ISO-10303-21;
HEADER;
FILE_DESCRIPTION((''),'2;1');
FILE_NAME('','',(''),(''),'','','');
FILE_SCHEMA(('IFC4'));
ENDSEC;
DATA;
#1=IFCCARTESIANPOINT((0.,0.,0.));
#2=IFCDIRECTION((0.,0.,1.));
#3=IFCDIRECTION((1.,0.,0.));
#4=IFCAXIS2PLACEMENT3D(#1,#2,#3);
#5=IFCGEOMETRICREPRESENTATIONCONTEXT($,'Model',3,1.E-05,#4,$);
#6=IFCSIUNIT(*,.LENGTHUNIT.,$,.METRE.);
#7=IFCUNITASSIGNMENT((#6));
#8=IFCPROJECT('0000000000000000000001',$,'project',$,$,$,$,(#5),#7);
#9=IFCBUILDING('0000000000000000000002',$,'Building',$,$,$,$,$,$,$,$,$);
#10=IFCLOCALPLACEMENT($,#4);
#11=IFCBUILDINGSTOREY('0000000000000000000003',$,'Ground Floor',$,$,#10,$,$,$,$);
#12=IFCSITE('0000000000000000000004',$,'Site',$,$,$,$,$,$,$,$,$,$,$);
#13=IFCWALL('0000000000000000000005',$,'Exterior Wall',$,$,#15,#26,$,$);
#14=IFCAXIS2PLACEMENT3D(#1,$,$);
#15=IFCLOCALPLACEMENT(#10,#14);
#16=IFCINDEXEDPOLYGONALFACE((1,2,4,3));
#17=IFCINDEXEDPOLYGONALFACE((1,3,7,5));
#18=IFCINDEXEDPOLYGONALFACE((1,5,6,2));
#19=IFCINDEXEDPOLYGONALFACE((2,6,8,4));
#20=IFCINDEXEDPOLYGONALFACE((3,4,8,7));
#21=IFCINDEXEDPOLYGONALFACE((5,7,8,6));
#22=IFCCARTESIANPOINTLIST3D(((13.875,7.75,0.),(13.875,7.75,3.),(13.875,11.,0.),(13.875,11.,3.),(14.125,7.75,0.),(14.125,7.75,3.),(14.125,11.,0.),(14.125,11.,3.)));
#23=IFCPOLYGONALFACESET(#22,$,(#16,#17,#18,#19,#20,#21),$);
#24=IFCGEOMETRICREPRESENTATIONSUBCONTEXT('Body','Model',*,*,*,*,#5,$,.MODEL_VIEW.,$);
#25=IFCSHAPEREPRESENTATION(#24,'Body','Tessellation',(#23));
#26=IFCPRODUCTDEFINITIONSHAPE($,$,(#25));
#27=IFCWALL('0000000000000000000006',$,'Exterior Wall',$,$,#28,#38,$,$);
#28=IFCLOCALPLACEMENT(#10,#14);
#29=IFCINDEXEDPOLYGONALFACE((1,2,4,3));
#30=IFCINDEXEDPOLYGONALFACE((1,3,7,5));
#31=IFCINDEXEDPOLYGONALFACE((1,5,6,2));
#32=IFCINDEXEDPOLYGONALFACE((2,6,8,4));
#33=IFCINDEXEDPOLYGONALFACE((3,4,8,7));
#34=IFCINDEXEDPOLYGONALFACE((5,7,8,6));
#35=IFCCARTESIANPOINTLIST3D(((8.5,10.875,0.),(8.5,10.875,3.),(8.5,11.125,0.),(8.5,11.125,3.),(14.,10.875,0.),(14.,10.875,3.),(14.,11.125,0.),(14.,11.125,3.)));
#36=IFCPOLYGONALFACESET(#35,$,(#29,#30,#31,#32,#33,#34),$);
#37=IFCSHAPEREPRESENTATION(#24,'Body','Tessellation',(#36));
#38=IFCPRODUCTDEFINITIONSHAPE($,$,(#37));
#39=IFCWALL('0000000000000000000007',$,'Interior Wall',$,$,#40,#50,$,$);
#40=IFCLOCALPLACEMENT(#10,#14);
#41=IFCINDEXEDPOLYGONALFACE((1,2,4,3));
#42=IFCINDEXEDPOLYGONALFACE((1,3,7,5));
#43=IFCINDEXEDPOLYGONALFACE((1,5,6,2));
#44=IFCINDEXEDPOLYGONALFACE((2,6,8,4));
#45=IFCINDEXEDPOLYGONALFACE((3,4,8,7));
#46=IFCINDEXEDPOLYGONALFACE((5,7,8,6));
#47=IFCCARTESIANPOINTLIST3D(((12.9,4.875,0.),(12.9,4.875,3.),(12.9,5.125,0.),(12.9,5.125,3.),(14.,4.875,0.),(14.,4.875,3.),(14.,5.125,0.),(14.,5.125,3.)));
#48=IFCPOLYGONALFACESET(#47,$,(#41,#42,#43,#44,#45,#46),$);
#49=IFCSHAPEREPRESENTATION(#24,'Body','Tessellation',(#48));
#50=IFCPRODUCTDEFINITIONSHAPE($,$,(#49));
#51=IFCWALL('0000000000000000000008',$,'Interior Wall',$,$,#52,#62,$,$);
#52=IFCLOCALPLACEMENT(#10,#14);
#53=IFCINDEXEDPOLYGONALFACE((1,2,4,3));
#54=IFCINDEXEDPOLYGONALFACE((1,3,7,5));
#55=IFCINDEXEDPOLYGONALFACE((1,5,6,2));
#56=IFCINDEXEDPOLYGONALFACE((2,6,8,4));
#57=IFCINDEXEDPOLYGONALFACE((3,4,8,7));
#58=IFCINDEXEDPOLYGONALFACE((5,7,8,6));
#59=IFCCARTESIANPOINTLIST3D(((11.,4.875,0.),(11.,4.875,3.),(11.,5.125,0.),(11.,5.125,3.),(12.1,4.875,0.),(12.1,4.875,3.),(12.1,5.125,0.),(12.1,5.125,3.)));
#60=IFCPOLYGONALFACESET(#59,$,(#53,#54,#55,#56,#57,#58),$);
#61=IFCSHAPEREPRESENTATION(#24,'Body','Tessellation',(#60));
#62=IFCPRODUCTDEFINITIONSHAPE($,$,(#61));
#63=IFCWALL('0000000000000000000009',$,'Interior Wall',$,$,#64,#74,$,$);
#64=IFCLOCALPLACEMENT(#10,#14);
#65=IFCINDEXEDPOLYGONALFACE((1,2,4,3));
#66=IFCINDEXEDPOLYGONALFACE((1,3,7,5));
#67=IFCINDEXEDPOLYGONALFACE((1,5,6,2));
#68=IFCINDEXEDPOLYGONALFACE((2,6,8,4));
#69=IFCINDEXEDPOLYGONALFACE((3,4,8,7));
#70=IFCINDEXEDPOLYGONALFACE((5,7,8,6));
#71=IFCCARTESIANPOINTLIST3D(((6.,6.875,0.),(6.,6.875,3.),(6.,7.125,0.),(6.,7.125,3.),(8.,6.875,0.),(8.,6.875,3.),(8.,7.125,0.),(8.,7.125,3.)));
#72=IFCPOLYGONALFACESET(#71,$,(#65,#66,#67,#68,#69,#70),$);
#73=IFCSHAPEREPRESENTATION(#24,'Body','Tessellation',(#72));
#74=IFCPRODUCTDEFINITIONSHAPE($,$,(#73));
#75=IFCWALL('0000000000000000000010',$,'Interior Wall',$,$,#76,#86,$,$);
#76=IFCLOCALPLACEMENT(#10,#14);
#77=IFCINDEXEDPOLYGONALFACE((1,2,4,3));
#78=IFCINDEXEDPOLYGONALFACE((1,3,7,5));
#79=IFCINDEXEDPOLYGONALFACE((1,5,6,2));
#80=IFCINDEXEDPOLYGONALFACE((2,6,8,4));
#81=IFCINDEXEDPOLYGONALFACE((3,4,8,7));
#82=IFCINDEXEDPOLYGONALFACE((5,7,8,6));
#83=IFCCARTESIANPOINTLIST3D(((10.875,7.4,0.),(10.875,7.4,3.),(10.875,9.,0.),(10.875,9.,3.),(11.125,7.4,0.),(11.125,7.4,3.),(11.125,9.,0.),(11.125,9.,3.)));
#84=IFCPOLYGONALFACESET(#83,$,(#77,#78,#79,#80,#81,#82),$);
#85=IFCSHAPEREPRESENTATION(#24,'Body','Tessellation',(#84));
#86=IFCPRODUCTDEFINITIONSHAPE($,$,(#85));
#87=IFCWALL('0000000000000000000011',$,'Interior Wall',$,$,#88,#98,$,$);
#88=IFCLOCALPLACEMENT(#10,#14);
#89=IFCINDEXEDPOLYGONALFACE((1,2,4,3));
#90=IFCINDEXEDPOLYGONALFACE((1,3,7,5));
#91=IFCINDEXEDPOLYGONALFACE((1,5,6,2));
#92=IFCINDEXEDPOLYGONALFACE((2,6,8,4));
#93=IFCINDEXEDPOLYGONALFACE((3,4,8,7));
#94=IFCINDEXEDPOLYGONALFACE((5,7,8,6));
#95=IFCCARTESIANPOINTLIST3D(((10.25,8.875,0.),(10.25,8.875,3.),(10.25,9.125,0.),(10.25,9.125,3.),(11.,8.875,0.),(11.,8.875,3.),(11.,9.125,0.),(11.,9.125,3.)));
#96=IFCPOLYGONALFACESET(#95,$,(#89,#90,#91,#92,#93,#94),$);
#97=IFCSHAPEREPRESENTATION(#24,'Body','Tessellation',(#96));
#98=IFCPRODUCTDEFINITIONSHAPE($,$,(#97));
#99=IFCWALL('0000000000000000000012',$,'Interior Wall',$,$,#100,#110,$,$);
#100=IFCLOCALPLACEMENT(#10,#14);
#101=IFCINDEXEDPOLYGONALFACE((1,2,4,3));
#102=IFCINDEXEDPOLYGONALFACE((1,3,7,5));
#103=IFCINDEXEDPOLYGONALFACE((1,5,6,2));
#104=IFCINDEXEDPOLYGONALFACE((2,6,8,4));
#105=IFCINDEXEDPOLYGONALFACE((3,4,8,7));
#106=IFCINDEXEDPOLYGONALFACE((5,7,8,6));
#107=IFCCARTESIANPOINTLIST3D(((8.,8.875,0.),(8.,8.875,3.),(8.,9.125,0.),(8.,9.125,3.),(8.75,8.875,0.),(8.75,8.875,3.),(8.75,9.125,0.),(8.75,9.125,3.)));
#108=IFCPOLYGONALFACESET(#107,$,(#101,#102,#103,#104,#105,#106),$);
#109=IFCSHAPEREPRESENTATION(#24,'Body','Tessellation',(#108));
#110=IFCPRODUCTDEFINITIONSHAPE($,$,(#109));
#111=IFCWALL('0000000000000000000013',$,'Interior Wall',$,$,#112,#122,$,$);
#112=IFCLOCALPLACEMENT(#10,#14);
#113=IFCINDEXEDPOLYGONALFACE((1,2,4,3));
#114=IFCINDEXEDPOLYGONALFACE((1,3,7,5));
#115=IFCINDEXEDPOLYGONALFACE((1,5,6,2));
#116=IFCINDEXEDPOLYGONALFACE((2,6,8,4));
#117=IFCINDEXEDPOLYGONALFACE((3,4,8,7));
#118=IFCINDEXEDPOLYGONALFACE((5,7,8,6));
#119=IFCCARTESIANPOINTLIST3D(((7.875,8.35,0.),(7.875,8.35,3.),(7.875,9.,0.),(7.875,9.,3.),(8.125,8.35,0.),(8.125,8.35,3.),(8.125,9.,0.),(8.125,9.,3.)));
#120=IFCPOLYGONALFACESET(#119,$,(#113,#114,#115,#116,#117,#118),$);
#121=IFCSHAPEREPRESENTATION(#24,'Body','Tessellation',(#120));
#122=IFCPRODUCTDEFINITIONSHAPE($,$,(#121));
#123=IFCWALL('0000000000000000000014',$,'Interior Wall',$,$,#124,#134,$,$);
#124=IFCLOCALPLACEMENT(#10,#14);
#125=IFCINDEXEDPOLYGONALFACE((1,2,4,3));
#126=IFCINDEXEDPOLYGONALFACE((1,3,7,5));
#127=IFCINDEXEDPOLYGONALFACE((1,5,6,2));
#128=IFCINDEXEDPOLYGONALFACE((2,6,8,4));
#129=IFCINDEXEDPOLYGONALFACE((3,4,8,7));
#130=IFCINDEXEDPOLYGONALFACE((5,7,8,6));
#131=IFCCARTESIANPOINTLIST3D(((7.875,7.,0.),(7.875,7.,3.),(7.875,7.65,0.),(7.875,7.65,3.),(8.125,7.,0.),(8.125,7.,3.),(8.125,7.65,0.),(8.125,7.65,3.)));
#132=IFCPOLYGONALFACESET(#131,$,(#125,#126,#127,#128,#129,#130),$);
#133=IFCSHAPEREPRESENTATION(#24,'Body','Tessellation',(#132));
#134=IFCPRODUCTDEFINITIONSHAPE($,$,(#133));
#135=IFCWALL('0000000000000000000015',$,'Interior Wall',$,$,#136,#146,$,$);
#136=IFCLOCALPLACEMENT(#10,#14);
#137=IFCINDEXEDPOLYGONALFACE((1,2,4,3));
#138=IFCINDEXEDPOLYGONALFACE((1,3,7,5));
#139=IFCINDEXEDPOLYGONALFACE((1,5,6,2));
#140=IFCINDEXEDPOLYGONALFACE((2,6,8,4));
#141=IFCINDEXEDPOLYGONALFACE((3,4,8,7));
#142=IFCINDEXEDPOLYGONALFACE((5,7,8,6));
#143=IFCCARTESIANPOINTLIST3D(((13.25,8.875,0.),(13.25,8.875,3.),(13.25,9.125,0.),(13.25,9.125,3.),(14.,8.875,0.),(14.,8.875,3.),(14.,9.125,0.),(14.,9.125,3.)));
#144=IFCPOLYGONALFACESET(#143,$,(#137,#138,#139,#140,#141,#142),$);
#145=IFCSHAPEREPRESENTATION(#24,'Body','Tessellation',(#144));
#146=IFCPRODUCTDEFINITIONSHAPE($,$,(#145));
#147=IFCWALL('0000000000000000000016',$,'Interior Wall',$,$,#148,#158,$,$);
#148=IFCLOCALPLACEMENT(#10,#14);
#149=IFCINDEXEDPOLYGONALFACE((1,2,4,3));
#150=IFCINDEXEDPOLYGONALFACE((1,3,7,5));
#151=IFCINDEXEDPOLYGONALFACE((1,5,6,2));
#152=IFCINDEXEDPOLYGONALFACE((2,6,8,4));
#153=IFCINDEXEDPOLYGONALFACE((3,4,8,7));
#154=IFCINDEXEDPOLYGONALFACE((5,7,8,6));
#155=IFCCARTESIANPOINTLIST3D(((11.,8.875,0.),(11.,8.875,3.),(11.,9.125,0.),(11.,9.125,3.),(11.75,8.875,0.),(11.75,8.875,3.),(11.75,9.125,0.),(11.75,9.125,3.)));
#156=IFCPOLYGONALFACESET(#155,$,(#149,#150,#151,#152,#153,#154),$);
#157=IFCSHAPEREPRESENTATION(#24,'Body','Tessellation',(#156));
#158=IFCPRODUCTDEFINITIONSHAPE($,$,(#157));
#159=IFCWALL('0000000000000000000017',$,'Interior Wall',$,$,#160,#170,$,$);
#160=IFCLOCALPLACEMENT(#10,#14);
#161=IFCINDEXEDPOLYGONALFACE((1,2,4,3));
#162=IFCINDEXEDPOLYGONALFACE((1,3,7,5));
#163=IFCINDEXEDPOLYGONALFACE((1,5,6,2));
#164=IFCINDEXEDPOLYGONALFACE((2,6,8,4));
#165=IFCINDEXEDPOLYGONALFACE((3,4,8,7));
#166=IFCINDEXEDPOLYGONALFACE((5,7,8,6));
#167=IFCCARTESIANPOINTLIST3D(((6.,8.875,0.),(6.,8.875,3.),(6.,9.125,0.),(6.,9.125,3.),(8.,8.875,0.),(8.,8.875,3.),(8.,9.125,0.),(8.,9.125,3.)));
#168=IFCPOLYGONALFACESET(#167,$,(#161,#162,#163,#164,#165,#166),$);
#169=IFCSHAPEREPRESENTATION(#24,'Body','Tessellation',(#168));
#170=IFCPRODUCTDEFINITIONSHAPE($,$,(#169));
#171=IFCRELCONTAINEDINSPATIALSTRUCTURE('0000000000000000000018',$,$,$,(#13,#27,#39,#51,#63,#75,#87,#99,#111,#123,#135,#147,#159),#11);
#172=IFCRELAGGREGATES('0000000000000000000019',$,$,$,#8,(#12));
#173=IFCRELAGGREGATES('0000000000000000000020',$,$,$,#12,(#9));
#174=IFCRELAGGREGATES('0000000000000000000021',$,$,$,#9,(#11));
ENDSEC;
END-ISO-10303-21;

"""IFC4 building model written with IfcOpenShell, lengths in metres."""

from ifc_helpers import new_model, si_unit, frame, origin_with_axes, place, context, subcontext, project, spatial, indexed_curve, outline, extrude, element, save


model = new_model("IFC4")

# Units and contexts
model_context = context("Model", 3, precision=1e-05, world=origin_with_axes())
body_context = subcontext(model_context, "Body", "Model", "MODEL_VIEW")
ifc_project = project(units=[si_unit("LENGTHUNIT", "METRE")], contexts=[model_context])

# Site, building, storey
site = spatial("IfcSite", under=ifc_project, Name="Site")
building = spatial("IfcBuilding", under=site, Name="Building")
storey_placement = place(None, origin_with_axes())
storey = spatial("IfcBuildingStorey", under=building, at=storey_placement, Name="Ground Floor")

# Walls
wall_1_placement = place(storey_placement, frame((14.0, 7.75, 0.0), z_axis=(0.0, 0.0, 1.0), x_axis=(0.0, 1.0, 0.0)))
element("IfcWall", 1, at=wall_1_placement, inside=storey, Name="Exterior Wall", context=body_context, shape_type="SweptSolid", body=[
    extrude(outline(indexed_curve([(0.0, 0.0), (0.0, 0.25), (3.25, 0.25), (3.25, 0.0), (0.0, 0.0)], self_intersect=False)), frame((0.0, -0.125, 0.0), z_axis=(0.0, 0.0, 1.0), x_axis=(1.0, 0.0, 0.0)), (0.0, 0.0, 1.0), 3.0),
])
wall_2_placement = place(storey_placement, frame((14.0, 11.0, 0.0), z_axis=(0.0, 0.0, 1.0), x_axis=(-1.0, 0.0, 0.0)))
element("IfcWall", 2, at=wall_2_placement, inside=storey, Name="Exterior Wall", context=body_context, shape_type="SweptSolid", body=[
    extrude(outline(indexed_curve([(0.0, 0.0), (0.0, 0.25), (5.5, 0.25), (5.5, 0.0), (0.0, 0.0)], self_intersect=False)), frame((0.0, -0.125, 0.0), z_axis=(0.0, 0.0, 1.0), x_axis=(1.0, 0.0, 0.0)), (0.0, 0.0, 1.0), 3.0),
])
for number, where, z_axis, x_axis, name in (
    (3, (14.0, 5.0, 0.0), (0.0, 0.0, 1.0), (-1.0, 0.0, 0.0), "Interior Wall"),
    (4, (12.1, 5.0, 0.0), (0.0, 0.0, 1.0), (-1.0, 0.0, 0.0), "Interior Wall"),
):
    element("IfcWall", number, at=place(storey_placement, frame(where, z_axis=z_axis, x_axis=x_axis)), inside=storey, Name=name, context=body_context, shape_type="SweptSolid", body=[
        extrude(outline(indexed_curve([(0.0, 0.0), (0.0, 0.25), (1.1, 0.25), (1.1, 0.0), (0.0, 0.0)], self_intersect=False)), frame((0.0, -0.125, 0.0), z_axis=(0.0, 0.0, 1.0), x_axis=(1.0, 0.0, 0.0)), (0.0, 0.0, 1.0), 3.0),
    ])
wall_3_placement = place(storey_placement, frame((8.0, 7.0, 0.0), z_axis=(0.0, 0.0, 1.0), x_axis=(-1.0, 0.0, 0.0)))
element("IfcWall", 5, at=wall_3_placement, inside=storey, Name="Interior Wall", context=body_context, shape_type="SweptSolid", body=[
    extrude(outline(indexed_curve([(0.0, 0.0), (0.0, 0.25), (2.0, 0.25), (2.0, 0.0), (0.0, 0.0)], self_intersect=False)), frame((0.0, -0.125, 0.0), z_axis=(0.0, 0.0, 1.0), x_axis=(1.0, 0.0, 0.0)), (0.0, 0.0, 1.0), 3.0),
])
wall_4_placement = place(storey_placement, frame((11.0, 7.4, 0.0), z_axis=(0.0, 0.0, 1.0), x_axis=(0.0, 1.0, 0.0)))
element("IfcWall", 6, at=wall_4_placement, inside=storey, Name="Interior Wall", context=body_context, shape_type="SweptSolid", body=[
    extrude(outline(indexed_curve([(0.0, 0.0), (0.0, 0.25), (1.6, 0.25), (1.6, 0.0), (0.0, 0.0)], self_intersect=False)), frame((0.0, -0.125, 0.0), z_axis=(0.0, 0.0, 1.0), x_axis=(1.0, 0.0, 0.0)), (0.0, 0.0, 1.0), 3.0),
])
for number, where, z_axis, x_axis, name in (
    (7, (11.0, 9.0, 0.0), (0.0, 0.0, 1.0), (-1.0, 0.0, 0.0), "Interior Wall"),
    (8, (8.75, 9.0, 0.0), (0.0, 0.0, 1.0), (-1.0, 0.0, 0.0), "Interior Wall"),
):
    element("IfcWall", number, at=place(storey_placement, frame(where, z_axis=z_axis, x_axis=x_axis)), inside=storey, Name=name, context=body_context, shape_type="SweptSolid", body=[
        extrude(outline(indexed_curve([(0.0, 0.0), (0.0, 0.25), (0.75, 0.25), (0.75, 0.0), (0.0, 0.0)], self_intersect=False)), frame((0.0, -0.125, 0.0), z_axis=(0.0, 0.0, 1.0), x_axis=(1.0, 0.0, 0.0)), (0.0, 0.0, 1.0), 3.0),
    ])
for number, where, z_axis, x_axis, name in (
    (9, (8.0, 9.0, 0.0), (0.0, 0.0, 1.0), (0.0, -1.0, 0.0), "Interior Wall"),
    (10, (8.0, 7.65, 0.0), (0.0, 0.0, 1.0), (0.0, -1.0, 0.0), "Interior Wall"),
):
    element("IfcWall", number, at=place(storey_placement, frame(where, z_axis=z_axis, x_axis=x_axis)), inside=storey, Name=name, context=body_context, shape_type="SweptSolid", body=[
        extrude(outline(indexed_curve([(0.0, 0.0), (0.0, 0.25), (0.65, 0.25), (0.65, 0.0), (0.0, 0.0)], self_intersect=False)), frame((0.0, -0.125, 0.0), z_axis=(0.0, 0.0, 1.0), x_axis=(1.0, 0.0, 0.0)), (0.0, 0.0, 1.0), 3.0),
    ])
for number, where, z_axis, x_axis, name in (
    (11, (14.0, 9.0, 0.0), (0.0, 0.0, 1.0), (-1.0, 0.0, 0.0), "Interior Wall"),
    (12, (11.75, 9.0, 0.0), (0.0, 0.0, 1.0), (-1.0, 0.0, 0.0), "Interior Wall"),
):
    element("IfcWall", number, at=place(storey_placement, frame(where, z_axis=z_axis, x_axis=x_axis)), inside=storey, Name=name, context=body_context, shape_type="SweptSolid", body=[
        extrude(outline(indexed_curve([(0.0, 0.0), (0.0, 0.25), (0.75, 0.25), (0.75, 0.0), (0.0, 0.0)], self_intersect=False)), frame((0.0, -0.125, 0.0), z_axis=(0.0, 0.0, 1.0), x_axis=(1.0, 0.0, 0.0)), (0.0, 0.0, 1.0), 3.0),
    ])
wall_5_placement = place(storey_placement, frame((8.0, 9.0, 0.0), z_axis=(0.0, 0.0, 1.0), x_axis=(-1.0, 0.0, 0.0)))
element("IfcWall", 13, at=wall_5_placement, inside=storey, Name="Interior Wall", context=body_context, shape_type="SweptSolid", body=[
    extrude(outline(indexed_curve([(0.0, 0.0), (0.0, 0.25), (2.0, 0.25), (2.0, 0.0), (0.0, 0.0)], self_intersect=False)), frame((0.0, -0.125, 0.0), z_axis=(0.0, 0.0, 1.0), x_axis=(1.0, 0.0, 0.0)), (0.0, 0.0, 1.0), 3.0),
])

save(model, "model.ifc")
